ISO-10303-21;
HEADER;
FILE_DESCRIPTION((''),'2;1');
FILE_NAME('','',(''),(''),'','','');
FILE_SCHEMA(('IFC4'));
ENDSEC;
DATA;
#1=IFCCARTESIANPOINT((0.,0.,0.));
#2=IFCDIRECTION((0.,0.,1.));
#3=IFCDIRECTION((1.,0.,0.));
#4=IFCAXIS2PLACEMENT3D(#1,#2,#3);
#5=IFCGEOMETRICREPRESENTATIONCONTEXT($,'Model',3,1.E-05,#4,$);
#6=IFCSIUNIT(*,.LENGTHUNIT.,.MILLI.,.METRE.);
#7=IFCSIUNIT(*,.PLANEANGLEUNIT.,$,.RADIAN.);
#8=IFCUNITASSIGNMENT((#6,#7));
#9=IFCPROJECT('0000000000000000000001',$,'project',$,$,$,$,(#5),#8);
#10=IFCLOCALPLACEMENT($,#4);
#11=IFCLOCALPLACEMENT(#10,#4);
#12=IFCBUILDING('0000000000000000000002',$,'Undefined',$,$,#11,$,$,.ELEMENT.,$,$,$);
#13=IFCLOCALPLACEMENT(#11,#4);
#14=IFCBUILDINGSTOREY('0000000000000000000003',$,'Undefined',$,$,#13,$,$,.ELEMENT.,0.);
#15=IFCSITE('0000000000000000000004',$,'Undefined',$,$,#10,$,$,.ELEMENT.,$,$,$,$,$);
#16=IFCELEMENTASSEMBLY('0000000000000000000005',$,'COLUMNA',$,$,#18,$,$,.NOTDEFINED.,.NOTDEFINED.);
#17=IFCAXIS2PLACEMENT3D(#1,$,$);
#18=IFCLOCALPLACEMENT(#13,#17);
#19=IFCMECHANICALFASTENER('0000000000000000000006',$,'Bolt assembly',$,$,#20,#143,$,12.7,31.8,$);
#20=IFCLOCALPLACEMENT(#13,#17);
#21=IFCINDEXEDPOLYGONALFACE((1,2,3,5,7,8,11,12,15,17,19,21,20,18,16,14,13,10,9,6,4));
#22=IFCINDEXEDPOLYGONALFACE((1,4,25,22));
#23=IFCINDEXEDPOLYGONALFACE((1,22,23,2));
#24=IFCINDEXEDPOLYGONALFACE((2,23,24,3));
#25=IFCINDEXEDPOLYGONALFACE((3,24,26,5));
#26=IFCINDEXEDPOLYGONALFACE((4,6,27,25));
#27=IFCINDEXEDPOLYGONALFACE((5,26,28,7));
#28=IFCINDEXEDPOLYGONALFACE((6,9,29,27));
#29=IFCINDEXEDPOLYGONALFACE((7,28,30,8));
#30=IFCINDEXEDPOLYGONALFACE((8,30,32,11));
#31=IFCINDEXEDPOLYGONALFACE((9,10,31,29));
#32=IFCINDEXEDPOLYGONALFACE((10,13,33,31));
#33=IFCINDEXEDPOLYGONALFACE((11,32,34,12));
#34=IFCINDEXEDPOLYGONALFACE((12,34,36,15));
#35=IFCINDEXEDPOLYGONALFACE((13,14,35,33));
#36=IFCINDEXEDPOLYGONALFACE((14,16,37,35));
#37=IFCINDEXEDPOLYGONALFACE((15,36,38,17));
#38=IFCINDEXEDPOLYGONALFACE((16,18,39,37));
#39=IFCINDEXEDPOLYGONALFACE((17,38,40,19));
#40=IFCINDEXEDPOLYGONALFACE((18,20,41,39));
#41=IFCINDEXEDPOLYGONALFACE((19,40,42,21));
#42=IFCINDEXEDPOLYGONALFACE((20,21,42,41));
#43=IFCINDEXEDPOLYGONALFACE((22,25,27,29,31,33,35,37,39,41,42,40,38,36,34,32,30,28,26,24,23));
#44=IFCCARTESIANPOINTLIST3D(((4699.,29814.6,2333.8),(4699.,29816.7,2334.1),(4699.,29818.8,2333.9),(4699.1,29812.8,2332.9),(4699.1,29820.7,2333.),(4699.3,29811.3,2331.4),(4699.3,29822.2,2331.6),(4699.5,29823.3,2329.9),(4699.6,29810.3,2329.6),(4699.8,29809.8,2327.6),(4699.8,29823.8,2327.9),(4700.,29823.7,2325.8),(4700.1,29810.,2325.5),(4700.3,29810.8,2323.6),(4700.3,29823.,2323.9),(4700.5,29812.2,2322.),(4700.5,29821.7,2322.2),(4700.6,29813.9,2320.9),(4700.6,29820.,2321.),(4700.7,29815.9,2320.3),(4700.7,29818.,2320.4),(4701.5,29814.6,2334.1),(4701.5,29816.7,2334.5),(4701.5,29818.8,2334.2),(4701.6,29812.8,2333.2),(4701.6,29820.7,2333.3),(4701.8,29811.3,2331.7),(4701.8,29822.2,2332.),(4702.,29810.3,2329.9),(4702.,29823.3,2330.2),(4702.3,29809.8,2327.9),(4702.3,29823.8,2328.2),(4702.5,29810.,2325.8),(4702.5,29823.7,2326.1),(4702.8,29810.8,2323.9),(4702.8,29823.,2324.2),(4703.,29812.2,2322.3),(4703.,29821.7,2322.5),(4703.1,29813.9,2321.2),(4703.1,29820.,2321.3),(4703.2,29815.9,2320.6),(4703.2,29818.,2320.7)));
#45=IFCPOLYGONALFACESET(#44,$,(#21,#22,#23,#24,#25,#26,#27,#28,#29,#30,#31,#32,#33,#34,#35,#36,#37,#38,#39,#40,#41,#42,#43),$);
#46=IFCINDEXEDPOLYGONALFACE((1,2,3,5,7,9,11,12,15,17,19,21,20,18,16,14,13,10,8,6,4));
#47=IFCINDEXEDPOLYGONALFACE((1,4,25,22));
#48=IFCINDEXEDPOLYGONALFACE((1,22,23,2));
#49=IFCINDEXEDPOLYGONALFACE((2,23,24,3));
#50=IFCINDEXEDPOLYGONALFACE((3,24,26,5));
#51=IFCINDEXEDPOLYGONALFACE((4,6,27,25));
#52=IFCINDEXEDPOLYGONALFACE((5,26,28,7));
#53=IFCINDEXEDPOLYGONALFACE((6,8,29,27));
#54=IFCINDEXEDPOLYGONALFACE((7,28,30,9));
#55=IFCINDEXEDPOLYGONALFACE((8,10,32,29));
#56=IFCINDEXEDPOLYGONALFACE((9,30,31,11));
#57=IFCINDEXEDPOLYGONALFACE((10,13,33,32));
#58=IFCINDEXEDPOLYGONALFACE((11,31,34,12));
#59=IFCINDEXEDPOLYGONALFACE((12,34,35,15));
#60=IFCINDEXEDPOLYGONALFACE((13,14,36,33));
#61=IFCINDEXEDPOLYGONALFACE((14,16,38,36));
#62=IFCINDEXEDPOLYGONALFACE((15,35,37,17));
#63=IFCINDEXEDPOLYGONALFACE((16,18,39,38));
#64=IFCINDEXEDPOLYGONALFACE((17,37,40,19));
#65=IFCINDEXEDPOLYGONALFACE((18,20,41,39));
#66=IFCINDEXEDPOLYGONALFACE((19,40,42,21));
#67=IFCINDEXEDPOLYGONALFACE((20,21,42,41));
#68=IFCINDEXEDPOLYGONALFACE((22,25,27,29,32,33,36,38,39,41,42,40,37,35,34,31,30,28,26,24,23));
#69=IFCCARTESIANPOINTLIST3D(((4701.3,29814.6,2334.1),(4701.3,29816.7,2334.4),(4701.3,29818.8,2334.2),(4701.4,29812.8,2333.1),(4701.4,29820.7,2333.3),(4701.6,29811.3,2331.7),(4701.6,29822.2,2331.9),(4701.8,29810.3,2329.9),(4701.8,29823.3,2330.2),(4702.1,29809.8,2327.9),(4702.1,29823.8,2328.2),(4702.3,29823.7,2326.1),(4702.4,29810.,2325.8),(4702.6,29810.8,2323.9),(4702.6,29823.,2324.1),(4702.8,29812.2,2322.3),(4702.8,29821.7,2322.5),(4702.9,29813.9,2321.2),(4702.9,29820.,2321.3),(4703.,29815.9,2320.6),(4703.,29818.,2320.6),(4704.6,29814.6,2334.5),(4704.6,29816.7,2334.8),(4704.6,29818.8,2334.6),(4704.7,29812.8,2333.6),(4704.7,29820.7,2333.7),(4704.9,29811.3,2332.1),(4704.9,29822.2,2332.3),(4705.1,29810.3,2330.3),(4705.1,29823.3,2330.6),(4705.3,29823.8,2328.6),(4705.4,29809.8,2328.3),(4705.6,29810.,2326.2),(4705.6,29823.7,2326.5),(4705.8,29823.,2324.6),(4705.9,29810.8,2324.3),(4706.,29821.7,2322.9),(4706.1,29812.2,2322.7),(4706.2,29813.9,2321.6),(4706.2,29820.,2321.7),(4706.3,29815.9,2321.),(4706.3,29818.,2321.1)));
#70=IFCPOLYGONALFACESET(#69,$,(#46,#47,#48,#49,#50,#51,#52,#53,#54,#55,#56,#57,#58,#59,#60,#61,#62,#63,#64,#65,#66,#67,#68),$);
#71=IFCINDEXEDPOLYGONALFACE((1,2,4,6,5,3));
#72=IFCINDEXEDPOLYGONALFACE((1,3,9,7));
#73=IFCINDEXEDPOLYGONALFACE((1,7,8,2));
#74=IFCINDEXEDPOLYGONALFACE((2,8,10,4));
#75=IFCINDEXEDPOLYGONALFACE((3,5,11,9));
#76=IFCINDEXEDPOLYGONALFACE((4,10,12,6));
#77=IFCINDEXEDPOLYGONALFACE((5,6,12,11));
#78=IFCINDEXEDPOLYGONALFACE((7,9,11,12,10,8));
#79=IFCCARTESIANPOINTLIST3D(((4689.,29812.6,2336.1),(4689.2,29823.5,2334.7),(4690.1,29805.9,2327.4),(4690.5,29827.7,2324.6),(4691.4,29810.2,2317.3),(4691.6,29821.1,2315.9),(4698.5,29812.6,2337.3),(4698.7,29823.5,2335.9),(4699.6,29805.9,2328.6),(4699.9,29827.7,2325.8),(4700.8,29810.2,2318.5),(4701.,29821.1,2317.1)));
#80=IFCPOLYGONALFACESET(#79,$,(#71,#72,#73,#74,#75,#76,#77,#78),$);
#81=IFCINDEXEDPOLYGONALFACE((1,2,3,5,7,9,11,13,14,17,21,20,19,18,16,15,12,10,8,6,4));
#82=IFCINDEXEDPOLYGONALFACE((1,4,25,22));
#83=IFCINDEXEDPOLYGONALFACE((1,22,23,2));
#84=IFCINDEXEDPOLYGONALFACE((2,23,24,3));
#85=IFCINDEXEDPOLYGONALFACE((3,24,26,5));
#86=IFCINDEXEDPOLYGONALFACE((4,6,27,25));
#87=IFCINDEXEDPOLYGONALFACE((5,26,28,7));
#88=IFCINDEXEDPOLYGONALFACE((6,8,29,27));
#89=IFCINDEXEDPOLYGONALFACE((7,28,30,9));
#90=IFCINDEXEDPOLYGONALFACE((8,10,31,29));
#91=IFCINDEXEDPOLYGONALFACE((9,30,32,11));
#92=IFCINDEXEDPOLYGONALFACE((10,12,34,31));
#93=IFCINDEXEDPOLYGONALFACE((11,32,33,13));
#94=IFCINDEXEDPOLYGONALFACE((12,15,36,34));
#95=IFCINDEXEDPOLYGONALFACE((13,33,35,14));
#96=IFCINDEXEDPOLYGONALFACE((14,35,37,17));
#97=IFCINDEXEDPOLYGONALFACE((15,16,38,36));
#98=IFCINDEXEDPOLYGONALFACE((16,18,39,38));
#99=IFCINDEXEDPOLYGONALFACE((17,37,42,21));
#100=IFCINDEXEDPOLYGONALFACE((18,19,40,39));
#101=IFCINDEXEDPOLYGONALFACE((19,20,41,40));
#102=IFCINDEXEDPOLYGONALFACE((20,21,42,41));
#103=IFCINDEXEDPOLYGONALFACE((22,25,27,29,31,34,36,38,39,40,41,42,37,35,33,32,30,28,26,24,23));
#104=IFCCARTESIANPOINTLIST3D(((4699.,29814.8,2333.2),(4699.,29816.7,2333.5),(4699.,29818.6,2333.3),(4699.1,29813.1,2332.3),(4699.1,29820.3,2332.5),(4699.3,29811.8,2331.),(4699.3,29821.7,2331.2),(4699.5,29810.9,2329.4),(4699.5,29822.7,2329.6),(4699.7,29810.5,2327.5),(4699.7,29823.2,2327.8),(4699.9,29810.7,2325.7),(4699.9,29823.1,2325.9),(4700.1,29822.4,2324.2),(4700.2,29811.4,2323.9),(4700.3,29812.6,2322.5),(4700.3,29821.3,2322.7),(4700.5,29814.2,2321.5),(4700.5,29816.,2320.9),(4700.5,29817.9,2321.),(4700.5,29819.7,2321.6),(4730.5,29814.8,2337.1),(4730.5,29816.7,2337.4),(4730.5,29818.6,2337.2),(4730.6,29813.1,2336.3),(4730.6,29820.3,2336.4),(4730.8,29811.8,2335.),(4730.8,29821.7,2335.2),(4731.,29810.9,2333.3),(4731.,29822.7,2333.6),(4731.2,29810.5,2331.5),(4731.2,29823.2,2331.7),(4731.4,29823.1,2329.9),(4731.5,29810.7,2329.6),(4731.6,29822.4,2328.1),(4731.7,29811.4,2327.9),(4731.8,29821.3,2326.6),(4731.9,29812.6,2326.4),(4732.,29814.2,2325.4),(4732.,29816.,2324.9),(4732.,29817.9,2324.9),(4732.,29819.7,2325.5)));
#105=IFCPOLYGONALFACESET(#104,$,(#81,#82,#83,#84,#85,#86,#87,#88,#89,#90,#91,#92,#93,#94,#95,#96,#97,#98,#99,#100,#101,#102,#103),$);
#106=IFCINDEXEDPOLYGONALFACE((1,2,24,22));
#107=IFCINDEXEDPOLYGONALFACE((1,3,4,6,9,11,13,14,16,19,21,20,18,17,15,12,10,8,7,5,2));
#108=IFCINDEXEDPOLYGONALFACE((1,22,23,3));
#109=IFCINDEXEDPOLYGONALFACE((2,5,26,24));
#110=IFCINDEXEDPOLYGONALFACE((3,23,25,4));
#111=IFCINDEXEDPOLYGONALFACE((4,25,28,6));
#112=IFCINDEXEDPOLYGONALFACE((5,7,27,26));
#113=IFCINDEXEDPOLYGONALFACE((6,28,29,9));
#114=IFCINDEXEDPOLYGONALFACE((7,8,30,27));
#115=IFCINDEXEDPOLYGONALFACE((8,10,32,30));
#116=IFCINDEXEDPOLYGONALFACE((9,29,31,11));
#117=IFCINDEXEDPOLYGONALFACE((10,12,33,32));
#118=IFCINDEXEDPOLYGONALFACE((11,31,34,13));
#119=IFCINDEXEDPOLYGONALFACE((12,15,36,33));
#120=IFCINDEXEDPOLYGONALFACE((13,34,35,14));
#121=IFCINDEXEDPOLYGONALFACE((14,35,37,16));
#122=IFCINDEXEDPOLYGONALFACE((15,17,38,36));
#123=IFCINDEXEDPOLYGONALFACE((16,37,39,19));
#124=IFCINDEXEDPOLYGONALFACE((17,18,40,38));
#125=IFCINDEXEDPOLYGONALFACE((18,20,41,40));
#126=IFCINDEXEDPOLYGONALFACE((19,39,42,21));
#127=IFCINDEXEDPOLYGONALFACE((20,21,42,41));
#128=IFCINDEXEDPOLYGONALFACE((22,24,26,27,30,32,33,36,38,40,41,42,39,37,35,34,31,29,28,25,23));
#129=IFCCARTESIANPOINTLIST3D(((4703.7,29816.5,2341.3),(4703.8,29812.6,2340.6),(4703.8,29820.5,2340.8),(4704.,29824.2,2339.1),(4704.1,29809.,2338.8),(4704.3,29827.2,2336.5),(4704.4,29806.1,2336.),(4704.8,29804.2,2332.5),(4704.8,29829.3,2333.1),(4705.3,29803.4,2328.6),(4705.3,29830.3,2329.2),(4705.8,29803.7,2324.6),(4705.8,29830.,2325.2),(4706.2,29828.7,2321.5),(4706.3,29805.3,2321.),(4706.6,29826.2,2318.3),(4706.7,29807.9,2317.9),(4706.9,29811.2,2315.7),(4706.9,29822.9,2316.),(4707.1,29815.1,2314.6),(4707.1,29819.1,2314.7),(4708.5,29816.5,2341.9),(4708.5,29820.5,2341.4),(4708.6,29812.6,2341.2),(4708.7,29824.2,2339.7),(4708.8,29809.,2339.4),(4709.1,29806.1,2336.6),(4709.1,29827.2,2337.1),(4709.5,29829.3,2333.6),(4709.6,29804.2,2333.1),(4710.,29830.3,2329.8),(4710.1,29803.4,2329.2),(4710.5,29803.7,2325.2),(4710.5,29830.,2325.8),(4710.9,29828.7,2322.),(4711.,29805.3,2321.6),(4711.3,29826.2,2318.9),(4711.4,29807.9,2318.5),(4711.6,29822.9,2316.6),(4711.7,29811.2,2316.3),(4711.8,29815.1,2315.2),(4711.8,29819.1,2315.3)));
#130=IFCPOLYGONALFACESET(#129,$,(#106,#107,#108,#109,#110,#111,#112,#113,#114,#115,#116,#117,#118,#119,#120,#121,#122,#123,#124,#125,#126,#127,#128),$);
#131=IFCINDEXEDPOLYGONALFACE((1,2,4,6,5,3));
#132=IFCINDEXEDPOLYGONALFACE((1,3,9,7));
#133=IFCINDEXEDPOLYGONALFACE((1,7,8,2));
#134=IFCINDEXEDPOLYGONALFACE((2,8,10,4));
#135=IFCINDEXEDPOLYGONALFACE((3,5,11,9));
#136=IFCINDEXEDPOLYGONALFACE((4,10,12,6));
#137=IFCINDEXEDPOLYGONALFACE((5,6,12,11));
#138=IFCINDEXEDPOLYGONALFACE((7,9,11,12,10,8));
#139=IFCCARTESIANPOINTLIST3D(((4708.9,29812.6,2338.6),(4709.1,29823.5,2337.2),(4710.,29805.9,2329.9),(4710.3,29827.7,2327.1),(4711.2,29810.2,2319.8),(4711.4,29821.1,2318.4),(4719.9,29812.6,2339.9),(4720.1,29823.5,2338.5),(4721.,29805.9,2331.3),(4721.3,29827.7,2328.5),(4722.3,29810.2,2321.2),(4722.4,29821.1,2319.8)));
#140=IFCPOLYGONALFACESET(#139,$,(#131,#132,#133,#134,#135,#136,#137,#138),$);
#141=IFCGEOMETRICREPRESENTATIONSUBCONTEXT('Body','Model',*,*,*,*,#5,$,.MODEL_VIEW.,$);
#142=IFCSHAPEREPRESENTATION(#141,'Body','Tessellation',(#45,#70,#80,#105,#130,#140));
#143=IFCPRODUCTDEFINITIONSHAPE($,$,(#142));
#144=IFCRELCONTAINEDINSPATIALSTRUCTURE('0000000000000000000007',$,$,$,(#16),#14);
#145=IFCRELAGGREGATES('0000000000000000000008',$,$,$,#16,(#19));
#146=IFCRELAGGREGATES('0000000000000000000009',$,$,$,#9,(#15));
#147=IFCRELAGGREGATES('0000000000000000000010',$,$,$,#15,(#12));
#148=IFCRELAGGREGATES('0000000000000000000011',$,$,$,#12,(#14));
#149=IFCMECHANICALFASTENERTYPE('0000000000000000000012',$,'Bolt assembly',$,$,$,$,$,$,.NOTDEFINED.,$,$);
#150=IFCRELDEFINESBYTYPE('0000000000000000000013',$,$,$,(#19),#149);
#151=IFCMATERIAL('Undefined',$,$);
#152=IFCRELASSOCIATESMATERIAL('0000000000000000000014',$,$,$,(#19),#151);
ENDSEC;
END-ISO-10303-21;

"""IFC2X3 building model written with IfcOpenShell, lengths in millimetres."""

from ifc_helpers import new_model, si_unit, frame, origin_with_axes, origin_2d_with_axis, place, context, subcontext, project, spatial, polyline, circle, outline, extrude, source, transform, mapped, material, type_object, element, aggregate, save


model = new_model("IFC2X3")

# Units and contexts
model_context = context("Model", 3, precision=1e-05, world=origin_with_axes())
body_context = subcontext(model_context, "Body", "Model", "MODEL_VIEW")
ifc_project = project(units=[si_unit("LENGTHUNIT", "METRE", prefix="MILLI"), si_unit("PLANEANGLEUNIT", "RADIAN")], contexts=[model_context])

# Site, building, storey
site_placement = place(None, origin_with_axes())
site = spatial("IfcSite", under=ifc_project, at=site_placement, Name="Undefined", CompositionType="ELEMENT")
building_placement = place(site_placement, origin_with_axes())
building = spatial("IfcBuilding", under=site, at=building_placement, Name="Undefined", CompositionType="ELEMENT")
storey_placement = place(building_placement, origin_with_axes())
storey = spatial("IfcBuildingStorey", under=building, at=storey_placement, Name="Undefined", CompositionType="ELEMENT", Elevation=0.0)

# Element assembly
assembly_1_placement = place(storey_placement, origin_with_axes())
assembly_1 = element("IfcElementAssembly", 1, at=assembly_1_placement, inside=storey, Name="COLUMNA", AssemblyPlace="NOTDEFINED", PredefinedType="NOTDEFINED")

# Shared definitions
ifc_material_1 = material(Name="Undefined")
mechanical_fastener_type = type_object("IfcMechanicalFastenerType", Name="Bolt assembly")

# Mechanical fastener
shared_shape_1 = source(origin_with_axes(), body_context, "Body", "SweptSolid", [
    extrude(circle(Radius=7.0, at=origin_2d_with_axis()), frame((0.0, -2.4, 0.0), z_axis=(0.0, 1.0, 0.0), x_axis=(1.0, 0.0, 0.0)), (0.0, 0.0, 1.0), 2.5),
    extrude(circle(Radius=7.0, at=origin_2d_with_axis()), frame((0.0, -0.1, 0.0), z_axis=(0.0, 1.0, 0.0), x_axis=(1.0, 0.0, 0.0)), (0.0, 0.0, 1.0), 3.3),
    extrude(outline(polyline([(9.5, -5.5), (9.5, 5.5), (0.0, 11.0), (-9.5, 5.5), (-9.5, -5.5), (0.0, -11.0), (9.5, -5.5)])), frame((0.0, -12.0, 0.0), z_axis=(0.0, 1.0, 0.0), x_axis=(1.0, 0.0, 0.0)), (0.0, 0.0, 1.0), 9.5),
    extrude(circle(Radius=6.3, at=origin_2d_with_axis()), frame((0.0, -2.5, 0.0), z_axis=(0.0, 1.0, 0.0), x_axis=(1.0, 0.0, 0.0)), (0.0, 0.0, 1.0), 31.8),
    extrude(circle(Radius=13.5, at=origin_2d_with_axis()), frame((0.0, 3.2, 0.0), z_axis=(0.0, 1.0, 0.0), x_axis=(1.0, 0.0, 0.0)), (0.0, 0.0, 1.0), 4.8),
    extrude(outline(polyline([(9.5, -5.5), (9.5, 5.5), (0.0, 11.0), (-9.5, 5.5), (-9.5, -5.5), (0.0, -11.0), (9.5, -5.5)])), frame((0.0, 8.0, 0.0), z_axis=(0.0, 1.0, 0.0), x_axis=(1.0, 0.0, 0.0)), (0.0, 0.0, 1.0), 11.1),
])
mechanical_fastener_1_placement = place(assembly_1_placement, frame((4702.2, 29816.8, 2327.5), z_axis=(-0.098611, 0.606774, 0.788734), x_axis=(-0.075276, -0.794875, 0.602086)))
mechanical_fastener_1 = element("IfcMechanicalFastener", 2, at=mechanical_fastener_1_placement, type_object=mechanical_fastener_type, material=ifc_material_1, Name="Bolt assembly", NominalDiameter=12.7, NominalLength=31.8, context=body_context, shape_type="MappedRepresentation", body=[
    mapped(shared_shape_1, transform((0.0, 0.0, 0.0))),
])
aggregate(assembly_1, [mechanical_fastener_1])

save(model, "model.ifc")
